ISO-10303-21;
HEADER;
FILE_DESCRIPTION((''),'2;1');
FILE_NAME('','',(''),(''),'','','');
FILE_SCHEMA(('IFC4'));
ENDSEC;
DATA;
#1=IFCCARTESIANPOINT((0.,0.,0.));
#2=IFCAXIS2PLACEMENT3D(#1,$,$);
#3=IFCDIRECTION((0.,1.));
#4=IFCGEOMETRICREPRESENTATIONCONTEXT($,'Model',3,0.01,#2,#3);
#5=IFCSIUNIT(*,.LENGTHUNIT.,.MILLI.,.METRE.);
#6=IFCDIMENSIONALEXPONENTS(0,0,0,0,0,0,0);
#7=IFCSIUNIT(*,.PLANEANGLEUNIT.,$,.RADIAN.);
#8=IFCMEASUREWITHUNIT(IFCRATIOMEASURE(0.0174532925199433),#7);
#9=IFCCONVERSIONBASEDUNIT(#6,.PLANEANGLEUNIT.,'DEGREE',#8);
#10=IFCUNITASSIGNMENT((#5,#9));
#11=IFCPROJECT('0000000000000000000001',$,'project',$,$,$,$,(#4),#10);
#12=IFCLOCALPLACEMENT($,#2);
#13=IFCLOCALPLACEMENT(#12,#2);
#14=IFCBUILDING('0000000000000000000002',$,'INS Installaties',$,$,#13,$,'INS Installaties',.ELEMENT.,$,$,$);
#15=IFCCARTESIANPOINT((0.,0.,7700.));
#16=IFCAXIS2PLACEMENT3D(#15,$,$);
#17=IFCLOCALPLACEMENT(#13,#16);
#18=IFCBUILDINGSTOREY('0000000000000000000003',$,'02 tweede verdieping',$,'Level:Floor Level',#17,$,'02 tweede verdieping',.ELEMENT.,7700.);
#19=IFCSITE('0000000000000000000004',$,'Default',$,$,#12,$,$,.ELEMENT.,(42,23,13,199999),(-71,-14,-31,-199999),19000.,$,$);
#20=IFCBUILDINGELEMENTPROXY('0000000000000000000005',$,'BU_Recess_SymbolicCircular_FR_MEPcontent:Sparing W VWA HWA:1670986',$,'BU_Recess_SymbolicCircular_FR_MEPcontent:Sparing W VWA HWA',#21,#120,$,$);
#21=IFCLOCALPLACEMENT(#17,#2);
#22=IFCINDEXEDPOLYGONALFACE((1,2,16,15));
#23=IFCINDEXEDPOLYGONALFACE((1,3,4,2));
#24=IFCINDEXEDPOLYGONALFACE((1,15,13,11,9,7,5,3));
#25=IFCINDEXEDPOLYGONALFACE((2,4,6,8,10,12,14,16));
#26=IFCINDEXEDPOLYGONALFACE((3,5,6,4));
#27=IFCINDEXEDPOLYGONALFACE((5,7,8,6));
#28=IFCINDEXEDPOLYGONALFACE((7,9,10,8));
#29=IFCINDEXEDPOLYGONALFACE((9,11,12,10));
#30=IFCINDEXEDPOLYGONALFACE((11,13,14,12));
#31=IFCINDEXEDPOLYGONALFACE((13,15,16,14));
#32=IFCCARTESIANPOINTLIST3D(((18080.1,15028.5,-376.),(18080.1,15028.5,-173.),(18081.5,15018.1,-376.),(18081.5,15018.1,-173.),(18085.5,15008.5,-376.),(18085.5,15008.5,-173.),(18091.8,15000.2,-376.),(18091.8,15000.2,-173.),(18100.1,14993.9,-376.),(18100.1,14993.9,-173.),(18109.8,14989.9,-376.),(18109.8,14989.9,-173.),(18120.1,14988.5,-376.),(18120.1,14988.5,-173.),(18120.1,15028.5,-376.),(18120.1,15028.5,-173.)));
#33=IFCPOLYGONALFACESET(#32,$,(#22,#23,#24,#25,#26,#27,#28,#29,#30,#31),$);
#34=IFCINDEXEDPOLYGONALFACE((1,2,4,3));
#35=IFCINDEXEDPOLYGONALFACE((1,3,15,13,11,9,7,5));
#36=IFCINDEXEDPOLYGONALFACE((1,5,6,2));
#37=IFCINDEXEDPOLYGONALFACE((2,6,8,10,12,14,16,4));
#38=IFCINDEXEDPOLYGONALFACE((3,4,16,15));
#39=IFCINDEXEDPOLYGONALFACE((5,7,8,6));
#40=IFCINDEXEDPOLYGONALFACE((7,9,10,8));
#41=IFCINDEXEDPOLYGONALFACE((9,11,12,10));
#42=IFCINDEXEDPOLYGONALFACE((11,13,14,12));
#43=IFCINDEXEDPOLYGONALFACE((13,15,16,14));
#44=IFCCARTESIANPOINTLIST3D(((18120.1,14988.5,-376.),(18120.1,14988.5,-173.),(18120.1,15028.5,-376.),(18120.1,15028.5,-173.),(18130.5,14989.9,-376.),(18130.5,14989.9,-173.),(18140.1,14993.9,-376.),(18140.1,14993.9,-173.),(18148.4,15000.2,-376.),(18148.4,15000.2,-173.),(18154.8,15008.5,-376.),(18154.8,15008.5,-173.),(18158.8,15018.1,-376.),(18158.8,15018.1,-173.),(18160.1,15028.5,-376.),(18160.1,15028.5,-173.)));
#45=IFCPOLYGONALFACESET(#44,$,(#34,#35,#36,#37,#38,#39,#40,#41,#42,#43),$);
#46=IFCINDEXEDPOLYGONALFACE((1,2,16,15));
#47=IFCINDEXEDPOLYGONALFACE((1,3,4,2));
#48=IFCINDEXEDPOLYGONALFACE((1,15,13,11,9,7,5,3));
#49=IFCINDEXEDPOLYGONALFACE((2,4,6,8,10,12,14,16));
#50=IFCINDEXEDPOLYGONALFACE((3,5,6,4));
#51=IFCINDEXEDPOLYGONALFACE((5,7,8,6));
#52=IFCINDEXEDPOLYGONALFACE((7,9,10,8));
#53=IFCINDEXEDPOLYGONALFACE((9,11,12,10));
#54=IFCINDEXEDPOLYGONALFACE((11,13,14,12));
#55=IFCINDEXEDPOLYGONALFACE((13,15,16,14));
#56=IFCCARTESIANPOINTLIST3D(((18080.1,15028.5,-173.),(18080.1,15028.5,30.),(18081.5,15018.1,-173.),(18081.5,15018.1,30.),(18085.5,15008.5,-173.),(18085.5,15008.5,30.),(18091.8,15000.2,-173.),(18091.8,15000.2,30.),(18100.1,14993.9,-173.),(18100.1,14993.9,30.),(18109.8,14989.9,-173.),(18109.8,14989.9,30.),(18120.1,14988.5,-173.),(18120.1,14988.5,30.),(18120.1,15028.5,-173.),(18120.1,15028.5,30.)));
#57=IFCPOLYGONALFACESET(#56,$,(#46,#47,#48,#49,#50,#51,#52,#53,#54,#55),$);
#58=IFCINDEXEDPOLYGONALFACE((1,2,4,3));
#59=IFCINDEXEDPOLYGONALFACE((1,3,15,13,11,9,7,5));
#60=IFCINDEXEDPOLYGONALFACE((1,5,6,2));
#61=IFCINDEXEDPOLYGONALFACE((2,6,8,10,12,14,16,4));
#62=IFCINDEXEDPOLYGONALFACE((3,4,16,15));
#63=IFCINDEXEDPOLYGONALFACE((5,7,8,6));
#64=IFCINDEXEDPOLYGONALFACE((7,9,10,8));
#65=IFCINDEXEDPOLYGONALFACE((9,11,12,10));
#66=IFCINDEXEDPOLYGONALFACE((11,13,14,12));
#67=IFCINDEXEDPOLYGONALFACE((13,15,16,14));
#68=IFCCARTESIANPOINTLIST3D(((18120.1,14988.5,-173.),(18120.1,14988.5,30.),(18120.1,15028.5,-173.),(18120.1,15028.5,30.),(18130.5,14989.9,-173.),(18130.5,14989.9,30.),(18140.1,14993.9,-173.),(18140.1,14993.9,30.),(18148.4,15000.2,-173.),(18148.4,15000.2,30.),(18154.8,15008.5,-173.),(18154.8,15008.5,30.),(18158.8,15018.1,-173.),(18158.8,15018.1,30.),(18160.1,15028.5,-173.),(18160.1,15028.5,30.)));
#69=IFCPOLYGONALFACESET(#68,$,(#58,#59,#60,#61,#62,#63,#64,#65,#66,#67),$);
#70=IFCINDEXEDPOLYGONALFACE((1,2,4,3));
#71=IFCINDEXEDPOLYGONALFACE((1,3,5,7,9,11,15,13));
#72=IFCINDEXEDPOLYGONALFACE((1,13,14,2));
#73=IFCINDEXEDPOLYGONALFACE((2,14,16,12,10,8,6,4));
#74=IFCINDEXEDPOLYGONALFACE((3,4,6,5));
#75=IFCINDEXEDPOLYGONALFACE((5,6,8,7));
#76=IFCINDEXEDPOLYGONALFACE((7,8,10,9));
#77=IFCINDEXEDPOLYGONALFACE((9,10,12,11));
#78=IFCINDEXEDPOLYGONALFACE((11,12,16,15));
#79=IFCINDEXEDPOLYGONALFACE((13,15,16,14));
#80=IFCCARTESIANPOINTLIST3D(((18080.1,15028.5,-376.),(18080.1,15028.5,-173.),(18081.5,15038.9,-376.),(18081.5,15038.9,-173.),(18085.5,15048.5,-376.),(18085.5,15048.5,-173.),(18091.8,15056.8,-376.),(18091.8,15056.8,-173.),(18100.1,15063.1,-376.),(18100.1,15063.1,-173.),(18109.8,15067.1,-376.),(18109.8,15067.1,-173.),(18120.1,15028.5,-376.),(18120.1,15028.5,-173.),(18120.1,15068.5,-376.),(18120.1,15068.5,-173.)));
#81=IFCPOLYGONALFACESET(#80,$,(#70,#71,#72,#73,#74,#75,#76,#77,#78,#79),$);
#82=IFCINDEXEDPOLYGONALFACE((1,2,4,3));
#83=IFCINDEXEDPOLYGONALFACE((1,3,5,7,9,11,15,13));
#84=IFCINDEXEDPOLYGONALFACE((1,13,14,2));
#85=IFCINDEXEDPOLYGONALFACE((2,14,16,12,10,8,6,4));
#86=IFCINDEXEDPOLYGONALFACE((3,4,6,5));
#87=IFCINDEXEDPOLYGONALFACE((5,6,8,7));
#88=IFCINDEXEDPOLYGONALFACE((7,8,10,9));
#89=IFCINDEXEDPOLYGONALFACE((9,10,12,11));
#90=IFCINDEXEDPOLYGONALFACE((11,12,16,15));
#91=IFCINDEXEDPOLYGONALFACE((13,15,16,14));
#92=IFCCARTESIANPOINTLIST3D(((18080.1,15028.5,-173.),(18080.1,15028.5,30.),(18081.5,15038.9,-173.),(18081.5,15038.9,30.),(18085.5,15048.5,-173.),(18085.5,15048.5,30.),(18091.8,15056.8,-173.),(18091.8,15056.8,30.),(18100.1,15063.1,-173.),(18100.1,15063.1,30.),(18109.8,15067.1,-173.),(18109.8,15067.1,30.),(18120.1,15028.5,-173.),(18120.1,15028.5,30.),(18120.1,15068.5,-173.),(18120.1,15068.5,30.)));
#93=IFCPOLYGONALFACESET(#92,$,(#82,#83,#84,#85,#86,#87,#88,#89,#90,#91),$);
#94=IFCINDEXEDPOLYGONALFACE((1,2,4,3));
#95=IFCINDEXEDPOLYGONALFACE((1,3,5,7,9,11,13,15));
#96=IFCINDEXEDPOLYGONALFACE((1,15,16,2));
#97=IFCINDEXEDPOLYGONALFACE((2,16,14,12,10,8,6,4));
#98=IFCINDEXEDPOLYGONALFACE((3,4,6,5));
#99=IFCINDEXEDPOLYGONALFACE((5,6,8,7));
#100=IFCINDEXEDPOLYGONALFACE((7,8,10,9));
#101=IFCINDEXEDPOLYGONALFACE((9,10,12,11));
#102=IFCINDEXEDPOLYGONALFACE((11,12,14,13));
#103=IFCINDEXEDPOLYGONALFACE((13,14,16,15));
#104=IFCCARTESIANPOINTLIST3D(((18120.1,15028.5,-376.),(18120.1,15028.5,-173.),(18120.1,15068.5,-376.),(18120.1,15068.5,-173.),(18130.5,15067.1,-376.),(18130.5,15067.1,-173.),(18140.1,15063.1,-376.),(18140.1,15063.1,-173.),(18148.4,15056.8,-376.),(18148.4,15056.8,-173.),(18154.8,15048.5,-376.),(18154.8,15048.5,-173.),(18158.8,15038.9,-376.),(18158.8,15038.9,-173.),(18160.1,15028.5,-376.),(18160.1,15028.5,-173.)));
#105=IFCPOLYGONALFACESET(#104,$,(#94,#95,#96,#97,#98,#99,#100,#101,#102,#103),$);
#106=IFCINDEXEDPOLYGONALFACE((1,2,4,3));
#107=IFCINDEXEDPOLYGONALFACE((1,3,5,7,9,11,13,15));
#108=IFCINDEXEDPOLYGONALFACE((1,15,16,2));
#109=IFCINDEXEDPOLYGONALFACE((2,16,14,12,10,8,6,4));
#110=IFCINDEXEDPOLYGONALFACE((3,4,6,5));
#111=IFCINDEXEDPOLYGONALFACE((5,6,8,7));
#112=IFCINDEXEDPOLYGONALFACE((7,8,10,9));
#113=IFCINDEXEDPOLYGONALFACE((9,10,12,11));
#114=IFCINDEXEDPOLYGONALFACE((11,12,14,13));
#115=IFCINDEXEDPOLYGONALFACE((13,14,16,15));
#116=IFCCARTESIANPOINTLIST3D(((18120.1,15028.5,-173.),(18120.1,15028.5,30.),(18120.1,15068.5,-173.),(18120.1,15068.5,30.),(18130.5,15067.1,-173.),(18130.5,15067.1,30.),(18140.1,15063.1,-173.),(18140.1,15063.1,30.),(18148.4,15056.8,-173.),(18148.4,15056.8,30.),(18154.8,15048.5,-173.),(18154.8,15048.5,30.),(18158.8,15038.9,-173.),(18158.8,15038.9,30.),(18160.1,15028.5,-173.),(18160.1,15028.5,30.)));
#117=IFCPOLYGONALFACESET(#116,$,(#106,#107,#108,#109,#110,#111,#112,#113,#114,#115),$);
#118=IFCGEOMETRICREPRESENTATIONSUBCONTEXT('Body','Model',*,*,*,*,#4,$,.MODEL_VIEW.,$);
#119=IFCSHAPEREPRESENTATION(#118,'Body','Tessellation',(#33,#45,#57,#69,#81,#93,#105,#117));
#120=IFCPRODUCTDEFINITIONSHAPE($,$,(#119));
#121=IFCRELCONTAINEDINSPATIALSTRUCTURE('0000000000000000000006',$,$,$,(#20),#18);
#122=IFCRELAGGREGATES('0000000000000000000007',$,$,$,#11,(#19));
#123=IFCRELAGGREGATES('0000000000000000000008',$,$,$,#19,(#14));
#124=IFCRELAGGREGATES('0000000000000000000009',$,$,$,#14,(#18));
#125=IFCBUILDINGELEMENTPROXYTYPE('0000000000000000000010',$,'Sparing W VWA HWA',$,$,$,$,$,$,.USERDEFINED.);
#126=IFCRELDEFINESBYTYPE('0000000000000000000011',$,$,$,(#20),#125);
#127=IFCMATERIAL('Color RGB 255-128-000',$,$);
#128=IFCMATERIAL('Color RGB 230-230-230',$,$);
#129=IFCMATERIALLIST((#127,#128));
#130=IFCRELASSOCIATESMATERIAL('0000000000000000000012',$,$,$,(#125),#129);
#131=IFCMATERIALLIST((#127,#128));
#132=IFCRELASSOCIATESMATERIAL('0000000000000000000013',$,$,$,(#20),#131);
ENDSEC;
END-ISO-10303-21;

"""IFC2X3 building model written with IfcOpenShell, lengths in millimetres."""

from ifc_helpers import new_model, entity, si_unit, converted_unit, direction, frame, frame_2d, origin, place, context, subcontext, project, spatial, polyline, circle_curve, parameter, trimmed, segment, composite_curve, outline, extrude, source, transform, mapped, material, material_list, type_object, type_shapes, element, save


model = new_model("IFC2X3")

# Units and contexts
model_context = context("Model", 3, precision=0.01, world=origin(), true_north=direction((0.0, 1.0)))
body_context = subcontext(model_context, "Body", "Model", "MODEL_VIEW")
ifc_project = project(units=[si_unit("LENGTHUNIT", "METRE", prefix="MILLI"), converted_unit("PLANEANGLEUNIT", "DEGREE", entity("IfcRatioMeasure", 0.0174532925199433), si_unit("PLANEANGLEUNIT", "RADIAN"), dimensions=[0, 0, 0, 0, 0, 0, 0])], contexts=[model_context])

# Site, building, storey
site_placement = place(None, origin())
site = spatial("IfcSite", under=ifc_project, at=site_placement, Name="Default", CompositionType="ELEMENT", RefLatitude=(42, 23, 13, 199999), RefLongitude=(-71, -14, -31, -199999), RefElevation=19000.0)
building_placement = place(site_placement, origin())
building = spatial("IfcBuilding", under=site, at=building_placement, Name="INS Installaties", LongName="INS Installaties", CompositionType="ELEMENT")
storey_placement = place(building_placement, frame((0.0, 0.0, 7700.0)))
storey = spatial("IfcBuildingStorey", under=building, at=storey_placement, Name="02 tweede verdieping", ObjectType="Level:Floor Level", LongName="02 tweede verdieping", CompositionType="ELEMENT", Elevation=7700.0)

# Building element proxy
ifc_material_1 = material(Name="Color RGB 255-128-000")
ifc_material_2 = material(Name="Color RGB 230-230-230")
ifc_material_list_1 = material_list([ifc_material_1, ifc_material_2])
building_element_proxy_type_1 = type_object("IfcBuildingElementProxyType", Name="Sparing W VWA HWA", PredefinedType="USERDEFINED", material=ifc_material_list_1)
shared_shape_1 = source(origin(), body_context, "Body", "SweptSolid", [
    extrude(outline(composite_curve([segment(trimmed(circle_curve(frame_2d((13.3, 13.3), x_axis=(1.0, 0.0)), 40.0), [parameter(180.0)], [parameter(270.0)], True, "PARAMETER"), True, "CONTINUOUS"), segment(polyline([(13.3, -26.7), (13.3, 13.3)]), True, "CONTINUOUS"), segment(polyline([(13.3, 13.3), (-26.7, 13.3)]), True, "CONTINUOUS")], self_intersect=False)), frame((13.3, 13.3, -403.0), z_axis=(0.0, 0.0, 1.0), x_axis=(-1.0, 0.0, 0.0)), (0.0, 0.0, 1.0), 203.0),
    extrude(outline(composite_curve([segment(polyline([(-26.7, -13.3), (13.3, -13.3)]), True, "CONTINUOUS"), segment(polyline([(13.3, -13.3), (13.3, 26.7)]), True, "CONTINUOUS"), segment(trimmed(circle_curve(frame_2d((13.3, -13.3), x_axis=(1.0, 0.0)), 40.0), [parameter(90.0)], [parameter(180.0)], True, "PARAMETER"), True, "CONTINUOUS")], self_intersect=False)), frame((-13.3, 13.3, -403.0)), (0.0, 0.0, 1.0), 203.0),
    extrude(outline(composite_curve([segment(trimmed(circle_curve(frame_2d((13.3, 13.3), x_axis=(1.0, 0.0)), 40.0), [parameter(180.0)], [parameter(270.0)], True, "PARAMETER"), True, "CONTINUOUS"), segment(polyline([(13.3, -26.7), (13.3, 13.3)]), True, "CONTINUOUS"), segment(polyline([(13.3, 13.3), (-26.7, 13.3)]), True, "CONTINUOUS")], self_intersect=False)), frame((13.3, 13.3, -200.0), z_axis=(0.0, 0.0, 1.0), x_axis=(-1.0, 0.0, 0.0)), (0.0, 0.0, 1.0), 203.0),
    extrude(outline(composite_curve([segment(polyline([(-26.7, -13.3), (13.3, -13.3)]), True, "CONTINUOUS"), segment(polyline([(13.3, -13.3), (13.3, 26.7)]), True, "CONTINUOUS"), segment(trimmed(circle_curve(frame_2d((13.3, -13.3), x_axis=(1.0, 0.0)), 40.0), [parameter(90.0)], [parameter(180.0)], True, "PARAMETER"), True, "CONTINUOUS")], self_intersect=False)), frame((-13.3, 13.3, -200.0)), (0.0, 0.0, 1.0), 203.0),
    extrude(outline(composite_curve([segment(polyline([(-26.7, -13.3), (13.3, -13.3)]), True, "CONTINUOUS"), segment(polyline([(13.3, -13.3), (13.3, 26.7)]), True, "CONTINUOUS"), segment(trimmed(circle_curve(frame_2d((13.3, -13.3), x_axis=(1.0, 0.0)), 40.0), [parameter(90.0)], [parameter(180.0)], True, "PARAMETER"), True, "CONTINUOUS")], self_intersect=False)), frame((13.3, -13.3, -403.0), z_axis=(0.0, 0.0, 1.0), x_axis=(-1.0, 0.0, 0.0)), (0.0, 0.0, 1.0), 203.0),
    extrude(outline(composite_curve([segment(polyline([(-26.7, -13.3), (13.3, -13.3)]), True, "CONTINUOUS"), segment(polyline([(13.3, -13.3), (13.3, 26.7)]), True, "CONTINUOUS"), segment(trimmed(circle_curve(frame_2d((13.3, -13.3), x_axis=(1.0, 0.0)), 40.0), [parameter(90.0)], [parameter(180.0)], True, "PARAMETER"), True, "CONTINUOUS")], self_intersect=False)), frame((13.3, -13.3, -200.0), z_axis=(0.0, 0.0, 1.0), x_axis=(-1.0, 0.0, 0.0)), (0.0, 0.0, 1.0), 203.0),
    extrude(outline(composite_curve([segment(trimmed(circle_curve(frame_2d((13.3, 13.3), x_axis=(1.0, 0.0)), 40.0), [parameter(180.0)], [parameter(270.0)], True, "PARAMETER"), True, "CONTINUOUS"), segment(polyline([(13.3, -26.7), (13.3, 13.3)]), True, "CONTINUOUS"), segment(polyline([(13.3, 13.3), (-26.7, 13.3)]), True, "CONTINUOUS")], self_intersect=False)), frame((-13.3, -13.3, -403.0)), (0.0, 0.0, 1.0), 203.0),
    extrude(outline(composite_curve([segment(trimmed(circle_curve(frame_2d((13.3, 13.3), x_axis=(1.0, 0.0)), 40.0), [parameter(180.0)], [parameter(270.0)], True, "PARAMETER"), True, "CONTINUOUS"), segment(polyline([(13.3, -26.7), (13.3, 13.3)]), True, "CONTINUOUS"), segment(polyline([(13.3, 13.3), (-26.7, 13.3)]), True, "CONTINUOUS")], self_intersect=False)), frame((-13.3, -13.3, -200.0)), (0.0, 0.0, 1.0), 203.0),
])
type_shapes(building_element_proxy_type_1, [shared_shape_1])
ifc_material_list_2 = material_list([ifc_material_1, ifc_material_2])
proxy_1_placement = place(storey_placement, frame((18120.1, 15028.5, 27.0), z_axis=(0.0, 0.0, 1.0), x_axis=(-1.0, 0.0, 0.0)))
element("IfcBuildingElementProxy", 1, at=proxy_1_placement, inside=storey, type_object=building_element_proxy_type_1, material=ifc_material_list_2, Name="BU_Recess_SymbolicCircular_FR_MEPcontent:Sparing W VWA HWA:1670986", ObjectType="BU_Recess_SymbolicCircular_FR_MEPcontent:Sparing W VWA HWA", context=body_context, shape_type="MappedRepresentation", body=[
    mapped(shared_shape_1, transform((0.0, 0.0, 0.0), scale=1.0)),
])

save(model, "model.ifc")
